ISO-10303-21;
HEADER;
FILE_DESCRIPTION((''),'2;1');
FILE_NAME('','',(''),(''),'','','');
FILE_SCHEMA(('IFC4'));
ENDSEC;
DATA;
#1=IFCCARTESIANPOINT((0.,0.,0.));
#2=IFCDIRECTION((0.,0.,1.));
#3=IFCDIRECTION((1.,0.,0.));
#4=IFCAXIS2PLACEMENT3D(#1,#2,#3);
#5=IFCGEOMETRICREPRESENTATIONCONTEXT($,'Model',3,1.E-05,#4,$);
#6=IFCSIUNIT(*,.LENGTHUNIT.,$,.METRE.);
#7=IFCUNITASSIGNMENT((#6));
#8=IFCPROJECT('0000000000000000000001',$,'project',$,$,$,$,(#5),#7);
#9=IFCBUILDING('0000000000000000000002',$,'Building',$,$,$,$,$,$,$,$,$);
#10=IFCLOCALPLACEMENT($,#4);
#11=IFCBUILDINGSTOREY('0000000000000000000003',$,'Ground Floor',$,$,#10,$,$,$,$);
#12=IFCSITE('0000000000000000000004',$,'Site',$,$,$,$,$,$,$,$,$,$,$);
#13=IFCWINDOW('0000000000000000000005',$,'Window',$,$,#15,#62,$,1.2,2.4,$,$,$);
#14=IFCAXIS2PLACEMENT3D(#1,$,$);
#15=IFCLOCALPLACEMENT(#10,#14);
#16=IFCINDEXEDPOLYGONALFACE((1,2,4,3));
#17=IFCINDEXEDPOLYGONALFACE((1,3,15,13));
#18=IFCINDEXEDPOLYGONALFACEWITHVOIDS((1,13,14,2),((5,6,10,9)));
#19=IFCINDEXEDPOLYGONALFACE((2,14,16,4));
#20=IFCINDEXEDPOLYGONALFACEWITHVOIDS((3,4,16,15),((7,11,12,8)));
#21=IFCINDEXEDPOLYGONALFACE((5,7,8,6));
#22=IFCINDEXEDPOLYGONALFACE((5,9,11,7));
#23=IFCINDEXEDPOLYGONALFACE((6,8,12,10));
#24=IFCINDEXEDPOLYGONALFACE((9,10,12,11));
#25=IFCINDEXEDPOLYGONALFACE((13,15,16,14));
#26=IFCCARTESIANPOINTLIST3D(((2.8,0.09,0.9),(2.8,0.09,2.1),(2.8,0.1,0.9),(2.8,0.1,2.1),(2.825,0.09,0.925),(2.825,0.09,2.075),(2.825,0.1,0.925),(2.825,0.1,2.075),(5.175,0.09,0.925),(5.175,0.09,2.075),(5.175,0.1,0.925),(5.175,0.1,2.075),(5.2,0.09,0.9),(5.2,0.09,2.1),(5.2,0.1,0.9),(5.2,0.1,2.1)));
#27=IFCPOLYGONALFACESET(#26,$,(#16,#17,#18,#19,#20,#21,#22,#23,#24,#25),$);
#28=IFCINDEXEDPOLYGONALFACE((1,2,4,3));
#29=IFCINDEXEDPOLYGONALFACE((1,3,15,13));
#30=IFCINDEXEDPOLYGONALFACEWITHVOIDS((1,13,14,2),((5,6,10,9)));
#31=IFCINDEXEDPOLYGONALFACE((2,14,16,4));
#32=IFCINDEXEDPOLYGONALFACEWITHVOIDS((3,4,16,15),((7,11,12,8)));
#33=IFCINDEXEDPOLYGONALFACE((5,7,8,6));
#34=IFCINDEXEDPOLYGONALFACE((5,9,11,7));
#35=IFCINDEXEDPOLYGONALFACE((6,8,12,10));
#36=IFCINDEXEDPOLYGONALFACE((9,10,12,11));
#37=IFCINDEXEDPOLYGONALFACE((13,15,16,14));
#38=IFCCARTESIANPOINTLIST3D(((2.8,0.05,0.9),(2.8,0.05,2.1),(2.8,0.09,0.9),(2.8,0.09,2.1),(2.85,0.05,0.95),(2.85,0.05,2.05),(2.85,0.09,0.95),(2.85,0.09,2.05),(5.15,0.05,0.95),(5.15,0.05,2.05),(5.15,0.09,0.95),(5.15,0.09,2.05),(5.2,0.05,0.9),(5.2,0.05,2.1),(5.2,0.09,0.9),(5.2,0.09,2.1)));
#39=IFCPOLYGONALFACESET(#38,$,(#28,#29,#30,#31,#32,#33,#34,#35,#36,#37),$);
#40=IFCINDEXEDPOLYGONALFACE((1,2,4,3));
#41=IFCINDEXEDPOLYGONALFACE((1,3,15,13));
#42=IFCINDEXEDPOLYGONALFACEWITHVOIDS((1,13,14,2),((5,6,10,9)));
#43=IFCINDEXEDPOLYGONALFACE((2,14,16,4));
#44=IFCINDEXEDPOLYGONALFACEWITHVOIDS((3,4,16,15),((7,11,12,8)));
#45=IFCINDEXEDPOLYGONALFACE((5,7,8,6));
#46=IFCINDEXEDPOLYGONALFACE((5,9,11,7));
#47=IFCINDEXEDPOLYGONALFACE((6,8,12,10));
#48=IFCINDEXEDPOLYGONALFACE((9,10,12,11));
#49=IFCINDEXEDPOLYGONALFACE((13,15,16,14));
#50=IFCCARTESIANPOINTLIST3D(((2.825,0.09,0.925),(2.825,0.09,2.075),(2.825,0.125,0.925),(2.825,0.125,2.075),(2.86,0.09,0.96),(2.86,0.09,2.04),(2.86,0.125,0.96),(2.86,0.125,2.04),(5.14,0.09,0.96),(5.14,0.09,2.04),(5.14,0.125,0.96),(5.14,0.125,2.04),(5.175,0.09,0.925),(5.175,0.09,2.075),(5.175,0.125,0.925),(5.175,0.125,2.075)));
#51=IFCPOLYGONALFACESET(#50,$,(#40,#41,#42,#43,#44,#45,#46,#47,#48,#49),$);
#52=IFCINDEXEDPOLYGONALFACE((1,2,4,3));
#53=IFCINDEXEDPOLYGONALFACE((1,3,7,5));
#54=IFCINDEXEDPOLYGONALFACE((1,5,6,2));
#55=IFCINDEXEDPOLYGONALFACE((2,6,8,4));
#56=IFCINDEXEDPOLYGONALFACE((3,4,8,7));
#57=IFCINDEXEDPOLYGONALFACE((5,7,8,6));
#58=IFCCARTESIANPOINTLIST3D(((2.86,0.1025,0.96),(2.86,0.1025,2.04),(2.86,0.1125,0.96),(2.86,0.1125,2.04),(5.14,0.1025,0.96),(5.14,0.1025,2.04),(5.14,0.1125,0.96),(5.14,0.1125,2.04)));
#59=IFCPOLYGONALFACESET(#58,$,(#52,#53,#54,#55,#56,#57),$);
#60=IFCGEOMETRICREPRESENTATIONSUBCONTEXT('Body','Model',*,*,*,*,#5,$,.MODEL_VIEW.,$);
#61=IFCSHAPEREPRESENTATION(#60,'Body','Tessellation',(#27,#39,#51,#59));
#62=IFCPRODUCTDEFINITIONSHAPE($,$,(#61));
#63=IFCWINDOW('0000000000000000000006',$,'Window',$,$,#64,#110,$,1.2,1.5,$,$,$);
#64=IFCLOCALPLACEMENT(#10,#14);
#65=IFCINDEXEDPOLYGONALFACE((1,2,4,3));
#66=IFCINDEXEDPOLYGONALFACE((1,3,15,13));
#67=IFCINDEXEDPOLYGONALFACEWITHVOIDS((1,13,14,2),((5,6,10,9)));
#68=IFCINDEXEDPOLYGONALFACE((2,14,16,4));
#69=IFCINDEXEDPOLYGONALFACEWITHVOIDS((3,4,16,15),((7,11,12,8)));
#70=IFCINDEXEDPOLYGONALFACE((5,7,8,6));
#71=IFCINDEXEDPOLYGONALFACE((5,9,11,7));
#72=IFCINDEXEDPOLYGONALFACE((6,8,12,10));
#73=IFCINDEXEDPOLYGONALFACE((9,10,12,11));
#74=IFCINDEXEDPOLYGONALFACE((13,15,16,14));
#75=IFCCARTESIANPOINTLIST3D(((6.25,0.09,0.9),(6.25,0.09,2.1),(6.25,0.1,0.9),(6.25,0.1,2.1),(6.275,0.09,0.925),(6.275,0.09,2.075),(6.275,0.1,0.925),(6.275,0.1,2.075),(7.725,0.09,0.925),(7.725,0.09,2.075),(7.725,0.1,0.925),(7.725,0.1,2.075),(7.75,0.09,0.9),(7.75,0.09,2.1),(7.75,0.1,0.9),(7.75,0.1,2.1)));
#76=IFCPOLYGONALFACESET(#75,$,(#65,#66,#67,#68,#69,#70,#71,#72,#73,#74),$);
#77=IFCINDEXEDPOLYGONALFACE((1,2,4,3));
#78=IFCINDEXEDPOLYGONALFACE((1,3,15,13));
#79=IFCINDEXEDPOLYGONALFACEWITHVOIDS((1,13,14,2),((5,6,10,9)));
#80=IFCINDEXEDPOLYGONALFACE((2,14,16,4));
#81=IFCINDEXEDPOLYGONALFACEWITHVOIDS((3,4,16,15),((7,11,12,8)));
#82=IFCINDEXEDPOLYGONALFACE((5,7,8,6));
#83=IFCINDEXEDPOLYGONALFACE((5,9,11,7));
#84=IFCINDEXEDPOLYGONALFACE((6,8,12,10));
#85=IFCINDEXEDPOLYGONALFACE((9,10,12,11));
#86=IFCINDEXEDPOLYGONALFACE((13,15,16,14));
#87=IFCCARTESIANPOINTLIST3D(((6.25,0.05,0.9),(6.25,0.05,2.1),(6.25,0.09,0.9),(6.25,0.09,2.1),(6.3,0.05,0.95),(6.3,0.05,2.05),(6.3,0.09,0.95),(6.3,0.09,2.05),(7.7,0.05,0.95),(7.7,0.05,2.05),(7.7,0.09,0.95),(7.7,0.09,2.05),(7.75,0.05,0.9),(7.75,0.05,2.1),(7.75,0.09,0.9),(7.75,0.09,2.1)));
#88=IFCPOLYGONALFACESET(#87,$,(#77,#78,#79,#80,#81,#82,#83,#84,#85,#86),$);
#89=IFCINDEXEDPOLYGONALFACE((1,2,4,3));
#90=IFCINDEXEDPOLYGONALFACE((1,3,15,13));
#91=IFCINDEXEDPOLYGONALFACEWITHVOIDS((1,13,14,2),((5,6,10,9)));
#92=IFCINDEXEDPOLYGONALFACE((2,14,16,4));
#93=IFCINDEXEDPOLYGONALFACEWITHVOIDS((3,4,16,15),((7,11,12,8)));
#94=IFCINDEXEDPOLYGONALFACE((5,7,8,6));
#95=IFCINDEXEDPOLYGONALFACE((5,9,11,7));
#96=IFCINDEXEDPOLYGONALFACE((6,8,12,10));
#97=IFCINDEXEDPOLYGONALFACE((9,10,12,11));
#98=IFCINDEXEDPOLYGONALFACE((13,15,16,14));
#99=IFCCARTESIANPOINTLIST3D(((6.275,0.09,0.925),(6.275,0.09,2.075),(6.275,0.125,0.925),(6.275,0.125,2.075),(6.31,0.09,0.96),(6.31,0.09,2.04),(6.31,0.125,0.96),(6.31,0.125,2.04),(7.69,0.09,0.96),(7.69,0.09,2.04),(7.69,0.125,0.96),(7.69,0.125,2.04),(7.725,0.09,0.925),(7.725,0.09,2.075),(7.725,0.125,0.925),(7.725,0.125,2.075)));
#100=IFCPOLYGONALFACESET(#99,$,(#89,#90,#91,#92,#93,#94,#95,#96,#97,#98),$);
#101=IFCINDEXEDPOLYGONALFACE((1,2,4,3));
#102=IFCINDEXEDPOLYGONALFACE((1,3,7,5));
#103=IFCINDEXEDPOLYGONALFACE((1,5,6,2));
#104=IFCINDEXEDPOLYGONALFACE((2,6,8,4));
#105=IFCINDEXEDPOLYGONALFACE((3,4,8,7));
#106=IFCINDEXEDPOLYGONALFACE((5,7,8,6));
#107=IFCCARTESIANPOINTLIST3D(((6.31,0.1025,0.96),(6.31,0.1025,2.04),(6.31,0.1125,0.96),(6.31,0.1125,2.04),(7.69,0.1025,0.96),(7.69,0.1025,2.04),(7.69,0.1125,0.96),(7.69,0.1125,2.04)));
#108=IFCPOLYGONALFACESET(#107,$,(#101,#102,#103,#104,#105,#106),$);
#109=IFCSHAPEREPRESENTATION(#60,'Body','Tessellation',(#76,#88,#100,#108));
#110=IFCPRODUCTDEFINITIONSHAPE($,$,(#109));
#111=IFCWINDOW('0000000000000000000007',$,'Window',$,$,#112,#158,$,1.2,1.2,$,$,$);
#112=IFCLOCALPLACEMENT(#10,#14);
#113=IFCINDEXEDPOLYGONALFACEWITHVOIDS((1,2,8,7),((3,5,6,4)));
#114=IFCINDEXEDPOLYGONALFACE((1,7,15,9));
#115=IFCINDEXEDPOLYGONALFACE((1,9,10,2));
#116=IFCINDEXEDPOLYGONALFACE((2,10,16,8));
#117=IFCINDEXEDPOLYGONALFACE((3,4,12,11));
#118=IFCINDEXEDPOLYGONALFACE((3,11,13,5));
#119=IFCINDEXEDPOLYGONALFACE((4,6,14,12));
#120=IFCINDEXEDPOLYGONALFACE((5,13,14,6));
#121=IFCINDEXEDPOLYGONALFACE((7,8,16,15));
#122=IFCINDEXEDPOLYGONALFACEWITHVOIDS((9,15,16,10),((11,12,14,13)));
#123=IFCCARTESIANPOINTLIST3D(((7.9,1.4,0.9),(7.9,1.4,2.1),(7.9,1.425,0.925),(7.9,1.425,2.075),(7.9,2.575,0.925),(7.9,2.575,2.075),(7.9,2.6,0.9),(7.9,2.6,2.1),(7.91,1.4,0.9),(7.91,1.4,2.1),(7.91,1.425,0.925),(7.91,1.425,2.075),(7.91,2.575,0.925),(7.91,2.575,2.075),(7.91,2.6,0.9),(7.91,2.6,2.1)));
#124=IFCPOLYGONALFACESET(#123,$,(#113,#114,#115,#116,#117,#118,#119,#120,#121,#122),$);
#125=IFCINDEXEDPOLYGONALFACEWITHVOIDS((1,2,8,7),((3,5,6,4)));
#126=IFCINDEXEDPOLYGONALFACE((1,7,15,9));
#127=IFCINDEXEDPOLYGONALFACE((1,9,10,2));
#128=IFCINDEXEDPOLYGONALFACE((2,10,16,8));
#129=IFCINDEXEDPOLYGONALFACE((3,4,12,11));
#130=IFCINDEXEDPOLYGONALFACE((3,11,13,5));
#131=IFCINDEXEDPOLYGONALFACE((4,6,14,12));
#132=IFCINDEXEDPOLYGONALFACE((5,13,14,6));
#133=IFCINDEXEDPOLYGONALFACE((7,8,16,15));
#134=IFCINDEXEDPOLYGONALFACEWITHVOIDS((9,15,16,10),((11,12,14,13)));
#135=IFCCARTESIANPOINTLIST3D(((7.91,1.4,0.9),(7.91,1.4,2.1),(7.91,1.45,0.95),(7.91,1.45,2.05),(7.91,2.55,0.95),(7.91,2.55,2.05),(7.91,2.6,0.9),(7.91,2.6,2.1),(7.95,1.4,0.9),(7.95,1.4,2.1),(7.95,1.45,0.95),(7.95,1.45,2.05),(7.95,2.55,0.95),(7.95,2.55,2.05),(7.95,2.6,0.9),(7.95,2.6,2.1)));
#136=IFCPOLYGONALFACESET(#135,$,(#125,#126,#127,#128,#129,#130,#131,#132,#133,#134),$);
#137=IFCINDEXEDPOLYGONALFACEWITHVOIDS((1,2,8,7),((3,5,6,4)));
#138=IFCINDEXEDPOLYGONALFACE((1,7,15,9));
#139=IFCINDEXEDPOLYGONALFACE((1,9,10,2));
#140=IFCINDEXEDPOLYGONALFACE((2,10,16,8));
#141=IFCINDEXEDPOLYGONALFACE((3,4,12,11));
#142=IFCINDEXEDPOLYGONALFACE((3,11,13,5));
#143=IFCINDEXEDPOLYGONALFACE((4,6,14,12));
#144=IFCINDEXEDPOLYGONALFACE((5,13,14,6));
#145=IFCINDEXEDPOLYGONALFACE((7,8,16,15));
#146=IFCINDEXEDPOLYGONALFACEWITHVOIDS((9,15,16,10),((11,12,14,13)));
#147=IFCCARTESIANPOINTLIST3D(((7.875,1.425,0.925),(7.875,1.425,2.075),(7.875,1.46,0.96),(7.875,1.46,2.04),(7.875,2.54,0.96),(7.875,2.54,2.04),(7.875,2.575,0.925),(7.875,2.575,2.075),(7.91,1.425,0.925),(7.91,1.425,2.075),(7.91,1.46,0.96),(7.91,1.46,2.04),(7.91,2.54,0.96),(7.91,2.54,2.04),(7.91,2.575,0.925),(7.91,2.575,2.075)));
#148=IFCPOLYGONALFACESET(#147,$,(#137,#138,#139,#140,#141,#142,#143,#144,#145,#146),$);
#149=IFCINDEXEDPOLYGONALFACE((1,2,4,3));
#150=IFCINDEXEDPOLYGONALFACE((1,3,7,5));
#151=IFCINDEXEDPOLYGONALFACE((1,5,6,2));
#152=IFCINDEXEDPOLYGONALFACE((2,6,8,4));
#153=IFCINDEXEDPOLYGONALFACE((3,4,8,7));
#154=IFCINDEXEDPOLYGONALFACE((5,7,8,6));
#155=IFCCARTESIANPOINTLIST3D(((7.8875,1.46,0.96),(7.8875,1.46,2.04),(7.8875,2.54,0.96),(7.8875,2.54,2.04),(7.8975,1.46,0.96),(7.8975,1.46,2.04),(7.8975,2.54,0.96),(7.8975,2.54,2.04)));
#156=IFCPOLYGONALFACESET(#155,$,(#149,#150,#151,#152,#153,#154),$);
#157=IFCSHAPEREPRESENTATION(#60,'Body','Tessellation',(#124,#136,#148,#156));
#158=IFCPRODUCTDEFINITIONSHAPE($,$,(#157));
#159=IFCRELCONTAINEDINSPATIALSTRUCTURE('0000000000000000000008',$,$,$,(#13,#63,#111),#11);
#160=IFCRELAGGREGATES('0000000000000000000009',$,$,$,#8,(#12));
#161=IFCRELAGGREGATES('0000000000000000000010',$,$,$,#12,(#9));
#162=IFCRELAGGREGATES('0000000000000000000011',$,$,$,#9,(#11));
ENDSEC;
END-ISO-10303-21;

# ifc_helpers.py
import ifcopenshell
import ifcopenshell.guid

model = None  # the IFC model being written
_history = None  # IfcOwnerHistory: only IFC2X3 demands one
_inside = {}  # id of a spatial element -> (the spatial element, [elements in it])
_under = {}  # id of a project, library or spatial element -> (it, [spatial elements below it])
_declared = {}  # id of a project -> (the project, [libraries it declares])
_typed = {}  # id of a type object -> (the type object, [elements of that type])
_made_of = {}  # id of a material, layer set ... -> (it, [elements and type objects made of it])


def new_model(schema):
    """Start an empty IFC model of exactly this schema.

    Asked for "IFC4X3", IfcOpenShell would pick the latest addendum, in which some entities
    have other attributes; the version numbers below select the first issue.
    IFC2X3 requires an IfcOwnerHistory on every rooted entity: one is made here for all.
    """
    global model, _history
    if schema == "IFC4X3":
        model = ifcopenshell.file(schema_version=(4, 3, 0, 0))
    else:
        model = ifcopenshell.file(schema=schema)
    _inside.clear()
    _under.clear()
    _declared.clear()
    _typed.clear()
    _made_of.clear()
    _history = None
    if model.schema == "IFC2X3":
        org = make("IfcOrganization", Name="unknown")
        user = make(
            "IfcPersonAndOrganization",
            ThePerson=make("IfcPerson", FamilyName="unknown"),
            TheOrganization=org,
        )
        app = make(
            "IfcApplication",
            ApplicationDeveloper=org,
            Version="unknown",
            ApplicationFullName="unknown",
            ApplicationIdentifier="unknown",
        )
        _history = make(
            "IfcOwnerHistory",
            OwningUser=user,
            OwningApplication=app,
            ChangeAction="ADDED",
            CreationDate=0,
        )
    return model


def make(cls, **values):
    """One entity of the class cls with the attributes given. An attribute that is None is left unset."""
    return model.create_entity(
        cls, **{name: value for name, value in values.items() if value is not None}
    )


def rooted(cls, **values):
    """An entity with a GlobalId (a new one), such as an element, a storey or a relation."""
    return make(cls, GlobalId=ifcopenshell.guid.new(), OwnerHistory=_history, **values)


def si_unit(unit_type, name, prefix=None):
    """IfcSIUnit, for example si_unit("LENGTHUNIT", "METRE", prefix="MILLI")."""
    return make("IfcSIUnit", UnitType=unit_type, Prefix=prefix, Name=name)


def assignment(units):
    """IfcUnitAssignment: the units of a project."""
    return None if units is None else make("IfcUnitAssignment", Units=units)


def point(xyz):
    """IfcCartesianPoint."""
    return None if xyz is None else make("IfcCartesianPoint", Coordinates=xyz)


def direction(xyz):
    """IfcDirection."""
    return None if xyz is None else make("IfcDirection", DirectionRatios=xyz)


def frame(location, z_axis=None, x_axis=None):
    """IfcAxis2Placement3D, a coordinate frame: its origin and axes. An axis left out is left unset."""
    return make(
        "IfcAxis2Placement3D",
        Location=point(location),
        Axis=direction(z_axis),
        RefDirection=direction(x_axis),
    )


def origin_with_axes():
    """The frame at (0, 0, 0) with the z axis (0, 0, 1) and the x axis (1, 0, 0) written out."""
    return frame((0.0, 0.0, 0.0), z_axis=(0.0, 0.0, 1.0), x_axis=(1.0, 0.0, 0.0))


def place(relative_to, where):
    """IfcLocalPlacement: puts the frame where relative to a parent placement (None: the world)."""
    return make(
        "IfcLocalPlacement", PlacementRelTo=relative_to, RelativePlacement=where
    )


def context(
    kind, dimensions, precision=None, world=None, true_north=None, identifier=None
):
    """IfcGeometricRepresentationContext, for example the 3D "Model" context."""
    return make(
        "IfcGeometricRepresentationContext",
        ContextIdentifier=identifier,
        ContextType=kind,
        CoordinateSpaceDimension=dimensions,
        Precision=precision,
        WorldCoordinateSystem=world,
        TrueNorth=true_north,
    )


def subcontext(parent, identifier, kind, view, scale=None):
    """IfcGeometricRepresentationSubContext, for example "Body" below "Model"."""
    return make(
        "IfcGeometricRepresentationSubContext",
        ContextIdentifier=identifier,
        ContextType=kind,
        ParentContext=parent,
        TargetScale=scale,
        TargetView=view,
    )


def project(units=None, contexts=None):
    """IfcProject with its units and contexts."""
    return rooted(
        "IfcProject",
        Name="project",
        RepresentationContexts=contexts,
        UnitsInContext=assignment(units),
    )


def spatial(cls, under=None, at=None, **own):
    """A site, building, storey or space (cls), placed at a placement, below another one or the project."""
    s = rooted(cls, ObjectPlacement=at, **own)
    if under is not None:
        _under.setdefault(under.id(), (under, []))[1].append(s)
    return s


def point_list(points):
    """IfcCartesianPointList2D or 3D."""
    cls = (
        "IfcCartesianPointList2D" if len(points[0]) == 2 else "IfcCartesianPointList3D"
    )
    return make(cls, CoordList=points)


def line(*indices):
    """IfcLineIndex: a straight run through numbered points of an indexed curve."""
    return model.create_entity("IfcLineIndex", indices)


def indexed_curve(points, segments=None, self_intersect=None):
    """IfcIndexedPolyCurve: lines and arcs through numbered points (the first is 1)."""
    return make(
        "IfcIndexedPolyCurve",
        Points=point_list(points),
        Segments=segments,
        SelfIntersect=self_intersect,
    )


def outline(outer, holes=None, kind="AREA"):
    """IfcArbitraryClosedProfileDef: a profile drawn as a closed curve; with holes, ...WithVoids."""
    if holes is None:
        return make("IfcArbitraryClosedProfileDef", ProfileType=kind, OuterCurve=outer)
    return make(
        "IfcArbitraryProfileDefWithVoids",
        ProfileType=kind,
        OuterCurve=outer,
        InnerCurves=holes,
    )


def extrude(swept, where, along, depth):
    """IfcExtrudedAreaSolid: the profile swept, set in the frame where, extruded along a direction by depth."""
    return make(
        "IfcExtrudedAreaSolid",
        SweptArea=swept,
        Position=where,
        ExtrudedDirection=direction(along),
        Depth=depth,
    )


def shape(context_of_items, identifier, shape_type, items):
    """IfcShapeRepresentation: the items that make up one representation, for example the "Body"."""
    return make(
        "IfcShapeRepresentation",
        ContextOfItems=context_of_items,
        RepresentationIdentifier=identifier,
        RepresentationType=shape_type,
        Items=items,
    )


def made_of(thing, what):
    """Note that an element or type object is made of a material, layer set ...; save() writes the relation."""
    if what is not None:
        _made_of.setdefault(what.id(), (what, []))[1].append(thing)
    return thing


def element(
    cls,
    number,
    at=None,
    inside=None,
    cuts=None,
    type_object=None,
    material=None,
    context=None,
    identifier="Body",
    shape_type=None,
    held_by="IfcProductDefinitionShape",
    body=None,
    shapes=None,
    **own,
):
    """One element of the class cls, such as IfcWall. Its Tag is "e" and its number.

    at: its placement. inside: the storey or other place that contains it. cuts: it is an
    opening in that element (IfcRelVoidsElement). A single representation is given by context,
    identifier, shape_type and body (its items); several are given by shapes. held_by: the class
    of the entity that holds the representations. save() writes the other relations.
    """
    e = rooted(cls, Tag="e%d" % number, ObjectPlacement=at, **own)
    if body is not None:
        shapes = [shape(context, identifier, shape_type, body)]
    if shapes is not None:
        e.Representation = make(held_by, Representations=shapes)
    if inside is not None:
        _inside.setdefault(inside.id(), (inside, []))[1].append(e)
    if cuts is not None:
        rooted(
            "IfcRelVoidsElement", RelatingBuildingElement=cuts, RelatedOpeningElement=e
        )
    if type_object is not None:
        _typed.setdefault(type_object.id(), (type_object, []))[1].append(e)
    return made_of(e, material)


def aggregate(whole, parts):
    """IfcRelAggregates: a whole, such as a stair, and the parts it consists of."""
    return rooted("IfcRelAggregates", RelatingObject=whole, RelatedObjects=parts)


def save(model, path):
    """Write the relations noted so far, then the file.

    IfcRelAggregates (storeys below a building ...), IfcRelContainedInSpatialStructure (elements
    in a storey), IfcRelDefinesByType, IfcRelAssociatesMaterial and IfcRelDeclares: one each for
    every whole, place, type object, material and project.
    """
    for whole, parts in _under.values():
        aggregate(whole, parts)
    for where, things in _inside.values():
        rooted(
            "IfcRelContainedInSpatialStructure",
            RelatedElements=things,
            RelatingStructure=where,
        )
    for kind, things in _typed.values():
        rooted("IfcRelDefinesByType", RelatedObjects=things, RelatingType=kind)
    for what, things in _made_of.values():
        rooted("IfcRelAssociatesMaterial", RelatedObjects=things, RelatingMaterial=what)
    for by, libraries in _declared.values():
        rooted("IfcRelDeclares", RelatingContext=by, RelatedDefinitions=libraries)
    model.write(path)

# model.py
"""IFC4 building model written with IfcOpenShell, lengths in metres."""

from ifc_helpers import new_model, si_unit, frame, origin_with_axes, place, context, subcontext, project, spatial, line, indexed_curve, outline, extrude, element, save


model = new_model("IFC4")

# Units and contexts
model_context = context("Model", 3, precision=1e-05, world=origin_with_axes())
body_context = subcontext(model_context, "Body", "Model", "MODEL_VIEW")
ifc_project = project(units=[si_unit("LENGTHUNIT", "METRE")], contexts=[model_context])

# Site, building, storey
site = spatial("IfcSite", under=ifc_project, Name="Site")
building = spatial("IfcBuilding", under=site, Name="Building")
storey_placement = place(None, origin_with_axes())
storey = spatial("IfcBuildingStorey", under=building, at=storey_placement, Name="Ground Floor")

# Windows
window_1_placement = place(storey_placement, frame((2.8, 0.0, 0.9), z_axis=(0.0, 0.0, 1.0), x_axis=(1.0, 0.0, 0.0)))
element("IfcWindow", 1, at=window_1_placement, inside=storey, Name="Window", OverallHeight=1.2, OverallWidth=2.4, context=body_context, shape_type="SweptSolid", body=[
    extrude(outline(indexed_curve([(0.0, 0.0), (2.4, 0.0), (2.4, 1.2), (0.0, 1.2)], segments=[line(1, 2, 3, 4, 1)]), holes=[indexed_curve([(0.025, 0.025), (2.375, 0.025), (2.375, 1.175), (0.025, 1.175)], segments=[line(1, 2, 3, 4, 1)])]), frame((0.0, 0.09, 0.0), z_axis=(0.0, -1.0, 0.0), x_axis=(1.0, 0.0, 0.0)), (0.0, 0.0, -1.0), 0.01),
    extrude(outline(indexed_curve([(0.0, 0.0), (2.4, 0.0), (2.4, 1.2), (0.0, 1.2)], segments=[line(1, 2, 3, 4, 1)]), holes=[indexed_curve([(0.05, 0.05), (2.35, 0.05), (2.35, 1.15), (0.05, 1.15)], segments=[line(1, 2, 3, 4, 1)])]), frame((0.0, 0.05, 0.0), z_axis=(0.0, -1.0, 0.0), x_axis=(1.0, 0.0, 0.0)), (0.0, 0.0, -1.0), 0.04),
    extrude(outline(indexed_curve([(0.0, 0.0), (2.35, 0.0), (2.35, 1.15), (0.0, 1.15)], segments=[line(1, 2, 3, 4, 1)]), holes=[indexed_curve([(0.035, 0.035), (2.315, 0.035), (2.315, 1.115), (0.035, 1.115)], segments=[line(1, 2, 3, 4, 1)])]), frame((0.025, 0.09, 0.025), z_axis=(0.0, -1.0, 0.0), x_axis=(1.0, 0.0, 0.0)), (0.0, 0.0, -1.0), 0.035),
    extrude(outline(indexed_curve([(0.035, 0.035), (2.315, 0.035), (2.315, 1.115), (0.035, 1.115)], segments=[line(1, 2, 3, 4, 1)])), frame((0.025, 0.1025, 0.025), z_axis=(0.0, -1.0, 0.0), x_axis=(1.0, 0.0, 0.0)), (0.0, 0.0, -1.0), 0.01),
])
window_2_placement = place(storey_placement, frame((6.25, 0.0, 0.9), z_axis=(0.0, 0.0, 1.0), x_axis=(1.0, 0.0, 0.0)))
element("IfcWindow", 2, at=window_2_placement, inside=storey, Name="Window", OverallHeight=1.2, OverallWidth=1.5, context=body_context, shape_type="SweptSolid", body=[
    extrude(outline(indexed_curve([(0.0, 0.0), (1.5, 0.0), (1.5, 1.2), (0.0, 1.2)], segments=[line(1, 2, 3, 4, 1)]), holes=[indexed_curve([(0.025, 0.025), (1.475, 0.025), (1.475, 1.175), (0.025, 1.175)], segments=[line(1, 2, 3, 4, 1)])]), frame((0.0, 0.09, 0.0), z_axis=(0.0, -1.0, 0.0), x_axis=(1.0, 0.0, 0.0)), (0.0, 0.0, -1.0), 0.01),
    extrude(outline(indexed_curve([(0.0, 0.0), (1.5, 0.0), (1.5, 1.2), (0.0, 1.2)], segments=[line(1, 2, 3, 4, 1)]), holes=[indexed_curve([(0.05, 0.05), (1.45, 0.05), (1.45, 1.15), (0.05, 1.15)], segments=[line(1, 2, 3, 4, 1)])]), frame((0.0, 0.05, 0.0), z_axis=(0.0, -1.0, 0.0), x_axis=(1.0, 0.0, 0.0)), (0.0, 0.0, -1.0), 0.04),
    extrude(outline(indexed_curve([(0.0, 0.0), (1.45, 0.0), (1.45, 1.15), (0.0, 1.15)], segments=[line(1, 2, 3, 4, 1)]), holes=[indexed_curve([(0.035, 0.035), (1.415, 0.035), (1.415, 1.115), (0.035, 1.115)], segments=[line(1, 2, 3, 4, 1)])]), frame((0.025, 0.09, 0.025), z_axis=(0.0, -1.0, 0.0), x_axis=(1.0, 0.0, 0.0)), (0.0, 0.0, -1.0), 0.035),
    extrude(outline(indexed_curve([(0.035, 0.035), (1.415, 0.035), (1.415, 1.115), (0.035, 1.115)], segments=[line(1, 2, 3, 4, 1)])), frame((0.025, 0.1025, 0.025), z_axis=(0.0, -1.0, 0.0), x_axis=(1.0, 0.0, 0.0)), (0.0, 0.0, -1.0), 0.01),
])
window_3_placement = place(storey_placement, frame((8.0, 1.4, 0.9), z_axis=(0.0, 0.0, 1.0), x_axis=(0.0, 1.0, 0.0)))
element("IfcWindow", 3, at=window_3_placement, inside=storey, Name="Window", OverallHeight=1.2, OverallWidth=1.2, context=body_context, shape_type="SweptSolid", body=[
    extrude(outline(indexed_curve([(0.0, 0.0), (1.2, 0.0), (1.2, 1.2), (0.0, 1.2)], segments=[line(1, 2, 3, 4, 1)]), holes=[indexed_curve([(0.025, 0.025), (1.175, 0.025), (1.175, 1.175), (0.025, 1.175)], segments=[line(1, 2, 3, 4, 1)])]), frame((0.0, 0.09, 0.0), z_axis=(0.0, -1.0, 0.0), x_axis=(1.0, 0.0, 0.0)), (0.0, 0.0, -1.0), 0.01),
    extrude(outline(indexed_curve([(0.0, 0.0), (1.2, 0.0), (1.2, 1.2), (0.0, 1.2)], segments=[line(1, 2, 3, 4, 1)]), holes=[indexed_curve([(0.05, 0.05), (1.15, 0.05), (1.15, 1.15), (0.05, 1.15)], segments=[line(1, 2, 3, 4, 1)])]), frame((0.0, 0.05, 0.0), z_axis=(0.0, -1.0, 0.0), x_axis=(1.0, 0.0, 0.0)), (0.0, 0.0, -1.0), 0.04),
    extrude(outline(indexed_curve([(0.0, 0.0), (1.15, 0.0), (1.15, 1.15), (0.0, 1.15)], segments=[line(1, 2, 3, 4, 1)]), holes=[indexed_curve([(0.035, 0.035), (1.115, 0.035), (1.115, 1.115), (0.035, 1.115)], segments=[line(1, 2, 3, 4, 1)])]), frame((0.025, 0.09, 0.025), z_axis=(0.0, -1.0, 0.0), x_axis=(1.0, 0.0, 0.0)), (0.0, 0.0, -1.0), 0.035),
    extrude(outline(indexed_curve([(0.035, 0.035), (1.115, 0.035), (1.115, 1.115), (0.035, 1.115)], segments=[line(1, 2, 3, 4, 1)])), frame((0.025, 0.1025, 0.025), z_axis=(0.0, -1.0, 0.0), x_axis=(1.0, 0.0, 0.0)), (0.0, 0.0, -1.0), 0.01),
])

save(model, "model.ifc")
